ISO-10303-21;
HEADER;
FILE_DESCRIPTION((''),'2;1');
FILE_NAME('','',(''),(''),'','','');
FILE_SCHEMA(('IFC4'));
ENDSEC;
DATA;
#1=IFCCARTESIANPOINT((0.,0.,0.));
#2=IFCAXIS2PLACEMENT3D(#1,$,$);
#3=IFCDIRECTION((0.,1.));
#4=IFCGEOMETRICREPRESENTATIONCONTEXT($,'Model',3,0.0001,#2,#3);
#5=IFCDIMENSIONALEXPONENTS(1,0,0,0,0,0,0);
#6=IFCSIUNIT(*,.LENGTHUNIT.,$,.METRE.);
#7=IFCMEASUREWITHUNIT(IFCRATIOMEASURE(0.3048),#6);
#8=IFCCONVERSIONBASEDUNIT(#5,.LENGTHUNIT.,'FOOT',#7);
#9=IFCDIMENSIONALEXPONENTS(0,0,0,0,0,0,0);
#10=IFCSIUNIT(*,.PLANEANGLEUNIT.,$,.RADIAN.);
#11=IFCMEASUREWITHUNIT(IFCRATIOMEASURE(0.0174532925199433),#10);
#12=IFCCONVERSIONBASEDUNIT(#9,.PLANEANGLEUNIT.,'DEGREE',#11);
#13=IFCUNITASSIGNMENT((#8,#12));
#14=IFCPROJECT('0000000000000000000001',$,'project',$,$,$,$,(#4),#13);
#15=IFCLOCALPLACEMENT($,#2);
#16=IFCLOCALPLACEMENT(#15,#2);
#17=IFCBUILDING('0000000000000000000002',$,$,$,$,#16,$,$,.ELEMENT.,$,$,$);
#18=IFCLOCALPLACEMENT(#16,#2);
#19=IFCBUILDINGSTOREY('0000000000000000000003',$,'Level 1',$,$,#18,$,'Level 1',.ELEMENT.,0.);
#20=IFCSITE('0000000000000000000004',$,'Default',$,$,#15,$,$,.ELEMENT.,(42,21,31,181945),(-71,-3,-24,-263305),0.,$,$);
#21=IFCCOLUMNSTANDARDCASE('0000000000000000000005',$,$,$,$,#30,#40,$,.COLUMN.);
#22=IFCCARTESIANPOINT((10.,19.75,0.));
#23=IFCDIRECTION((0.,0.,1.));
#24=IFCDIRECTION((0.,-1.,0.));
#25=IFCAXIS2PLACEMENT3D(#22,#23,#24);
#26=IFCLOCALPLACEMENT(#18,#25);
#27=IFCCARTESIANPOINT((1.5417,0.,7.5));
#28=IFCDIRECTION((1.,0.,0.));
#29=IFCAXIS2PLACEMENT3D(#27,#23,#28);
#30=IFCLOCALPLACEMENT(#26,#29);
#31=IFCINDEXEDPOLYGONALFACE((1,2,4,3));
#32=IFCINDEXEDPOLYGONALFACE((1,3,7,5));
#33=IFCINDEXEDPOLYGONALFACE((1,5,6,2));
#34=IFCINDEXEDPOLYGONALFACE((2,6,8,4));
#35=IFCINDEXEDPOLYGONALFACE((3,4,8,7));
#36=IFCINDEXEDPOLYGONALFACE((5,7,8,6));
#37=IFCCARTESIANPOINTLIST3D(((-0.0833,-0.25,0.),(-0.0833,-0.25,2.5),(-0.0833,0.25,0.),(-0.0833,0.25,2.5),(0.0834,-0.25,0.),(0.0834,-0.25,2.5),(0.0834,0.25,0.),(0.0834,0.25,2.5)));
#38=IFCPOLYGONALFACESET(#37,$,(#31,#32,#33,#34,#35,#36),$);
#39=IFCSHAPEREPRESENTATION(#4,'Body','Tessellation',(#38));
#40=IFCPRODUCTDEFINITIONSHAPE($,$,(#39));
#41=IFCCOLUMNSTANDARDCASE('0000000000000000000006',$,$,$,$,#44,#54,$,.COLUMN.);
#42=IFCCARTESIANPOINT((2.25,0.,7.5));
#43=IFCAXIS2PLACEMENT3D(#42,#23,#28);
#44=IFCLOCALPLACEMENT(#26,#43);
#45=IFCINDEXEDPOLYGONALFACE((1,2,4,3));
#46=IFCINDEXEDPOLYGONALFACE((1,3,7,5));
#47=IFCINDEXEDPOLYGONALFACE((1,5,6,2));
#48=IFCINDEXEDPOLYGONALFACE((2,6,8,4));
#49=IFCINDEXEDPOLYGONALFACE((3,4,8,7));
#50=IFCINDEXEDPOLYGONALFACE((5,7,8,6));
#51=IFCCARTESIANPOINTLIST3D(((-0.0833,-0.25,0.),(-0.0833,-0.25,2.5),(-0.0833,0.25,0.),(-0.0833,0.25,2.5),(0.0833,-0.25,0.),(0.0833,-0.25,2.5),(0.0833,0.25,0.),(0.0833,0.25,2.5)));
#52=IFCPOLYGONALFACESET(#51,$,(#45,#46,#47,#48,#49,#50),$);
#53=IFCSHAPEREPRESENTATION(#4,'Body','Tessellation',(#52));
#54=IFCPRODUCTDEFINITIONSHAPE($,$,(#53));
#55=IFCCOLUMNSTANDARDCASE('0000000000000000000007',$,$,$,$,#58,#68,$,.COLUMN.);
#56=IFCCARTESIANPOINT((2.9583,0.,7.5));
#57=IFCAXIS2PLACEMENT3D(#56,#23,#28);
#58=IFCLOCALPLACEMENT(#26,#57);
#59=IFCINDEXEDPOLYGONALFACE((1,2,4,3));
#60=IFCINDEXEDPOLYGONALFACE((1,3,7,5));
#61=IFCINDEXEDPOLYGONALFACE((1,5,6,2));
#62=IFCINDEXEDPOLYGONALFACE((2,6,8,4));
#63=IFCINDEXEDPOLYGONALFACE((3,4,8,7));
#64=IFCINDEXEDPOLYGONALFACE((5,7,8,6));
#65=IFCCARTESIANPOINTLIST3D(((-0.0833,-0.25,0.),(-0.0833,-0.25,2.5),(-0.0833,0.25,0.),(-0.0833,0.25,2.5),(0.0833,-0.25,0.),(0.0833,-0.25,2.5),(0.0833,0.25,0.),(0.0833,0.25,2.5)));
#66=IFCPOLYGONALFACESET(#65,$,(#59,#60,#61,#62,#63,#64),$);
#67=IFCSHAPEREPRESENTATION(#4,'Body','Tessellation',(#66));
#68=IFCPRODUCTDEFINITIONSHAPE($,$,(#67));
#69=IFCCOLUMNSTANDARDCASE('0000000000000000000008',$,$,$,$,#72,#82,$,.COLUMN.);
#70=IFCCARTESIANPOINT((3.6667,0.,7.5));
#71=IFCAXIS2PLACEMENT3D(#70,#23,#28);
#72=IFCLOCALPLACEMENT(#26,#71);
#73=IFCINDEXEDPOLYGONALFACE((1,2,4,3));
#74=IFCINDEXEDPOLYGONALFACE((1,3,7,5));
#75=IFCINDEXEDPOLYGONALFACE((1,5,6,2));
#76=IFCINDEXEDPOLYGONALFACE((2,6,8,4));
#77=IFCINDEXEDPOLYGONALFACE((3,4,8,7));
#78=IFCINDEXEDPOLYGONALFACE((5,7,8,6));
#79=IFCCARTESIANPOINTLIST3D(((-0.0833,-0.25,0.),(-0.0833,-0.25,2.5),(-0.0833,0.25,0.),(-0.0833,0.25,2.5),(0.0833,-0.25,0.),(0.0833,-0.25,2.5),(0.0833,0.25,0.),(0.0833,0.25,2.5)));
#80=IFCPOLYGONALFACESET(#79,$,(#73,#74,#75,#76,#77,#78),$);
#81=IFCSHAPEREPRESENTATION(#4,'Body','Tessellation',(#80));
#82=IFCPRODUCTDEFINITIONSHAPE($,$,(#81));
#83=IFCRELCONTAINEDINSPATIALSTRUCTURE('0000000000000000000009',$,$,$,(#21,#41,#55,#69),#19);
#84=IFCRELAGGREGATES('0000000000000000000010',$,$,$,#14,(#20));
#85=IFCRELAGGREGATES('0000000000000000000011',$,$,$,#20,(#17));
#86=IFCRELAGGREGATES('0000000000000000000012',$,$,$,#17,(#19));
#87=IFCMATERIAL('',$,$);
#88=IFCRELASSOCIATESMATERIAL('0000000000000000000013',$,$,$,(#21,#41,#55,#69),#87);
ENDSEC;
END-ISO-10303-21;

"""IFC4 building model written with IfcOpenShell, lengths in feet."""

from ifc_helpers import new_model, entity, si_unit, converted_unit, direction, frame, origin, place, context, project, spatial, rectangle, extrude, material, element, save


model = new_model("IFC4")

# Units and contexts
model_context = context("Model", 3, precision=0.0001, world=origin(), true_north=direction((0.0, 1.0)))
ifc_project = project(units=[converted_unit("LENGTHUNIT", "FOOT", entity("IfcRatioMeasure", 0.3048), si_unit("LENGTHUNIT", "METRE"), dimensions=[1, 0, 0, 0, 0, 0, 0]), converted_unit("PLANEANGLEUNIT", "DEGREE", entity("IfcRatioMeasure", 0.0174532925199433), si_unit("PLANEANGLEUNIT", "RADIAN"), dimensions=[0, 0, 0, 0, 0, 0, 0])], contexts=[model_context])

# Site, building, storey
site_placement = place(None, origin())
site = spatial("IfcSite", under=ifc_project, at=site_placement, Name="Default", CompositionType="ELEMENT", RefLatitude=(42, 21, 31, 181945), RefLongitude=(-71, -3, -24, -263305), RefElevation=0.0)
building_placement = place(site_placement, origin())
building = spatial("IfcBuilding", under=site, at=building_placement, CompositionType="ELEMENT")
storey_placement = place(building_placement, origin())
storey = spatial("IfcBuildingStorey", under=building, at=storey_placement, Name="Level 1", LongName="Level 1", CompositionType="ELEMENT", Elevation=0.0)

# Columns
wall_1_placement = place(storey_placement, frame((10.0, 19.75, 0.0), z_axis=(0.0, 0.0, 1.0), x_axis=(0.0, -1.0, 0.0)))
ifc_material_1 = material(Name="")
for number, where, z_axis, x_axis in (
    (1, (1.5417, 0.0, 7.5), (0.0, 0.0, 1.0), (1.0, 0.0, 0.0)),
    (2, (2.25, 0.0, 7.5), (0.0, 0.0, 1.0), (1.0, 0.0, 0.0)),
    (3, (2.9583, 0.0, 7.5), (0.0, 0.0, 1.0), (1.0, 0.0, 0.0)),
    (4, (3.6667, 0.0, 7.5), (0.0, 0.0, 1.0), (1.0, 0.0, 0.0)),
):
    element("IfcColumnStandardCase", number, at=place(wall_1_placement, frame(where, z_axis=z_axis, x_axis=x_axis)), inside=storey, material=ifc_material_1, PredefinedType="COLUMN", context=model_context, shape_type="SweptSolid", body=[
        extrude(rectangle(XDim=0.1667, YDim=0.5), origin(), (0.0, 0.0, 1.0), 2.5),
    ])

save(model, "model.ifc")
